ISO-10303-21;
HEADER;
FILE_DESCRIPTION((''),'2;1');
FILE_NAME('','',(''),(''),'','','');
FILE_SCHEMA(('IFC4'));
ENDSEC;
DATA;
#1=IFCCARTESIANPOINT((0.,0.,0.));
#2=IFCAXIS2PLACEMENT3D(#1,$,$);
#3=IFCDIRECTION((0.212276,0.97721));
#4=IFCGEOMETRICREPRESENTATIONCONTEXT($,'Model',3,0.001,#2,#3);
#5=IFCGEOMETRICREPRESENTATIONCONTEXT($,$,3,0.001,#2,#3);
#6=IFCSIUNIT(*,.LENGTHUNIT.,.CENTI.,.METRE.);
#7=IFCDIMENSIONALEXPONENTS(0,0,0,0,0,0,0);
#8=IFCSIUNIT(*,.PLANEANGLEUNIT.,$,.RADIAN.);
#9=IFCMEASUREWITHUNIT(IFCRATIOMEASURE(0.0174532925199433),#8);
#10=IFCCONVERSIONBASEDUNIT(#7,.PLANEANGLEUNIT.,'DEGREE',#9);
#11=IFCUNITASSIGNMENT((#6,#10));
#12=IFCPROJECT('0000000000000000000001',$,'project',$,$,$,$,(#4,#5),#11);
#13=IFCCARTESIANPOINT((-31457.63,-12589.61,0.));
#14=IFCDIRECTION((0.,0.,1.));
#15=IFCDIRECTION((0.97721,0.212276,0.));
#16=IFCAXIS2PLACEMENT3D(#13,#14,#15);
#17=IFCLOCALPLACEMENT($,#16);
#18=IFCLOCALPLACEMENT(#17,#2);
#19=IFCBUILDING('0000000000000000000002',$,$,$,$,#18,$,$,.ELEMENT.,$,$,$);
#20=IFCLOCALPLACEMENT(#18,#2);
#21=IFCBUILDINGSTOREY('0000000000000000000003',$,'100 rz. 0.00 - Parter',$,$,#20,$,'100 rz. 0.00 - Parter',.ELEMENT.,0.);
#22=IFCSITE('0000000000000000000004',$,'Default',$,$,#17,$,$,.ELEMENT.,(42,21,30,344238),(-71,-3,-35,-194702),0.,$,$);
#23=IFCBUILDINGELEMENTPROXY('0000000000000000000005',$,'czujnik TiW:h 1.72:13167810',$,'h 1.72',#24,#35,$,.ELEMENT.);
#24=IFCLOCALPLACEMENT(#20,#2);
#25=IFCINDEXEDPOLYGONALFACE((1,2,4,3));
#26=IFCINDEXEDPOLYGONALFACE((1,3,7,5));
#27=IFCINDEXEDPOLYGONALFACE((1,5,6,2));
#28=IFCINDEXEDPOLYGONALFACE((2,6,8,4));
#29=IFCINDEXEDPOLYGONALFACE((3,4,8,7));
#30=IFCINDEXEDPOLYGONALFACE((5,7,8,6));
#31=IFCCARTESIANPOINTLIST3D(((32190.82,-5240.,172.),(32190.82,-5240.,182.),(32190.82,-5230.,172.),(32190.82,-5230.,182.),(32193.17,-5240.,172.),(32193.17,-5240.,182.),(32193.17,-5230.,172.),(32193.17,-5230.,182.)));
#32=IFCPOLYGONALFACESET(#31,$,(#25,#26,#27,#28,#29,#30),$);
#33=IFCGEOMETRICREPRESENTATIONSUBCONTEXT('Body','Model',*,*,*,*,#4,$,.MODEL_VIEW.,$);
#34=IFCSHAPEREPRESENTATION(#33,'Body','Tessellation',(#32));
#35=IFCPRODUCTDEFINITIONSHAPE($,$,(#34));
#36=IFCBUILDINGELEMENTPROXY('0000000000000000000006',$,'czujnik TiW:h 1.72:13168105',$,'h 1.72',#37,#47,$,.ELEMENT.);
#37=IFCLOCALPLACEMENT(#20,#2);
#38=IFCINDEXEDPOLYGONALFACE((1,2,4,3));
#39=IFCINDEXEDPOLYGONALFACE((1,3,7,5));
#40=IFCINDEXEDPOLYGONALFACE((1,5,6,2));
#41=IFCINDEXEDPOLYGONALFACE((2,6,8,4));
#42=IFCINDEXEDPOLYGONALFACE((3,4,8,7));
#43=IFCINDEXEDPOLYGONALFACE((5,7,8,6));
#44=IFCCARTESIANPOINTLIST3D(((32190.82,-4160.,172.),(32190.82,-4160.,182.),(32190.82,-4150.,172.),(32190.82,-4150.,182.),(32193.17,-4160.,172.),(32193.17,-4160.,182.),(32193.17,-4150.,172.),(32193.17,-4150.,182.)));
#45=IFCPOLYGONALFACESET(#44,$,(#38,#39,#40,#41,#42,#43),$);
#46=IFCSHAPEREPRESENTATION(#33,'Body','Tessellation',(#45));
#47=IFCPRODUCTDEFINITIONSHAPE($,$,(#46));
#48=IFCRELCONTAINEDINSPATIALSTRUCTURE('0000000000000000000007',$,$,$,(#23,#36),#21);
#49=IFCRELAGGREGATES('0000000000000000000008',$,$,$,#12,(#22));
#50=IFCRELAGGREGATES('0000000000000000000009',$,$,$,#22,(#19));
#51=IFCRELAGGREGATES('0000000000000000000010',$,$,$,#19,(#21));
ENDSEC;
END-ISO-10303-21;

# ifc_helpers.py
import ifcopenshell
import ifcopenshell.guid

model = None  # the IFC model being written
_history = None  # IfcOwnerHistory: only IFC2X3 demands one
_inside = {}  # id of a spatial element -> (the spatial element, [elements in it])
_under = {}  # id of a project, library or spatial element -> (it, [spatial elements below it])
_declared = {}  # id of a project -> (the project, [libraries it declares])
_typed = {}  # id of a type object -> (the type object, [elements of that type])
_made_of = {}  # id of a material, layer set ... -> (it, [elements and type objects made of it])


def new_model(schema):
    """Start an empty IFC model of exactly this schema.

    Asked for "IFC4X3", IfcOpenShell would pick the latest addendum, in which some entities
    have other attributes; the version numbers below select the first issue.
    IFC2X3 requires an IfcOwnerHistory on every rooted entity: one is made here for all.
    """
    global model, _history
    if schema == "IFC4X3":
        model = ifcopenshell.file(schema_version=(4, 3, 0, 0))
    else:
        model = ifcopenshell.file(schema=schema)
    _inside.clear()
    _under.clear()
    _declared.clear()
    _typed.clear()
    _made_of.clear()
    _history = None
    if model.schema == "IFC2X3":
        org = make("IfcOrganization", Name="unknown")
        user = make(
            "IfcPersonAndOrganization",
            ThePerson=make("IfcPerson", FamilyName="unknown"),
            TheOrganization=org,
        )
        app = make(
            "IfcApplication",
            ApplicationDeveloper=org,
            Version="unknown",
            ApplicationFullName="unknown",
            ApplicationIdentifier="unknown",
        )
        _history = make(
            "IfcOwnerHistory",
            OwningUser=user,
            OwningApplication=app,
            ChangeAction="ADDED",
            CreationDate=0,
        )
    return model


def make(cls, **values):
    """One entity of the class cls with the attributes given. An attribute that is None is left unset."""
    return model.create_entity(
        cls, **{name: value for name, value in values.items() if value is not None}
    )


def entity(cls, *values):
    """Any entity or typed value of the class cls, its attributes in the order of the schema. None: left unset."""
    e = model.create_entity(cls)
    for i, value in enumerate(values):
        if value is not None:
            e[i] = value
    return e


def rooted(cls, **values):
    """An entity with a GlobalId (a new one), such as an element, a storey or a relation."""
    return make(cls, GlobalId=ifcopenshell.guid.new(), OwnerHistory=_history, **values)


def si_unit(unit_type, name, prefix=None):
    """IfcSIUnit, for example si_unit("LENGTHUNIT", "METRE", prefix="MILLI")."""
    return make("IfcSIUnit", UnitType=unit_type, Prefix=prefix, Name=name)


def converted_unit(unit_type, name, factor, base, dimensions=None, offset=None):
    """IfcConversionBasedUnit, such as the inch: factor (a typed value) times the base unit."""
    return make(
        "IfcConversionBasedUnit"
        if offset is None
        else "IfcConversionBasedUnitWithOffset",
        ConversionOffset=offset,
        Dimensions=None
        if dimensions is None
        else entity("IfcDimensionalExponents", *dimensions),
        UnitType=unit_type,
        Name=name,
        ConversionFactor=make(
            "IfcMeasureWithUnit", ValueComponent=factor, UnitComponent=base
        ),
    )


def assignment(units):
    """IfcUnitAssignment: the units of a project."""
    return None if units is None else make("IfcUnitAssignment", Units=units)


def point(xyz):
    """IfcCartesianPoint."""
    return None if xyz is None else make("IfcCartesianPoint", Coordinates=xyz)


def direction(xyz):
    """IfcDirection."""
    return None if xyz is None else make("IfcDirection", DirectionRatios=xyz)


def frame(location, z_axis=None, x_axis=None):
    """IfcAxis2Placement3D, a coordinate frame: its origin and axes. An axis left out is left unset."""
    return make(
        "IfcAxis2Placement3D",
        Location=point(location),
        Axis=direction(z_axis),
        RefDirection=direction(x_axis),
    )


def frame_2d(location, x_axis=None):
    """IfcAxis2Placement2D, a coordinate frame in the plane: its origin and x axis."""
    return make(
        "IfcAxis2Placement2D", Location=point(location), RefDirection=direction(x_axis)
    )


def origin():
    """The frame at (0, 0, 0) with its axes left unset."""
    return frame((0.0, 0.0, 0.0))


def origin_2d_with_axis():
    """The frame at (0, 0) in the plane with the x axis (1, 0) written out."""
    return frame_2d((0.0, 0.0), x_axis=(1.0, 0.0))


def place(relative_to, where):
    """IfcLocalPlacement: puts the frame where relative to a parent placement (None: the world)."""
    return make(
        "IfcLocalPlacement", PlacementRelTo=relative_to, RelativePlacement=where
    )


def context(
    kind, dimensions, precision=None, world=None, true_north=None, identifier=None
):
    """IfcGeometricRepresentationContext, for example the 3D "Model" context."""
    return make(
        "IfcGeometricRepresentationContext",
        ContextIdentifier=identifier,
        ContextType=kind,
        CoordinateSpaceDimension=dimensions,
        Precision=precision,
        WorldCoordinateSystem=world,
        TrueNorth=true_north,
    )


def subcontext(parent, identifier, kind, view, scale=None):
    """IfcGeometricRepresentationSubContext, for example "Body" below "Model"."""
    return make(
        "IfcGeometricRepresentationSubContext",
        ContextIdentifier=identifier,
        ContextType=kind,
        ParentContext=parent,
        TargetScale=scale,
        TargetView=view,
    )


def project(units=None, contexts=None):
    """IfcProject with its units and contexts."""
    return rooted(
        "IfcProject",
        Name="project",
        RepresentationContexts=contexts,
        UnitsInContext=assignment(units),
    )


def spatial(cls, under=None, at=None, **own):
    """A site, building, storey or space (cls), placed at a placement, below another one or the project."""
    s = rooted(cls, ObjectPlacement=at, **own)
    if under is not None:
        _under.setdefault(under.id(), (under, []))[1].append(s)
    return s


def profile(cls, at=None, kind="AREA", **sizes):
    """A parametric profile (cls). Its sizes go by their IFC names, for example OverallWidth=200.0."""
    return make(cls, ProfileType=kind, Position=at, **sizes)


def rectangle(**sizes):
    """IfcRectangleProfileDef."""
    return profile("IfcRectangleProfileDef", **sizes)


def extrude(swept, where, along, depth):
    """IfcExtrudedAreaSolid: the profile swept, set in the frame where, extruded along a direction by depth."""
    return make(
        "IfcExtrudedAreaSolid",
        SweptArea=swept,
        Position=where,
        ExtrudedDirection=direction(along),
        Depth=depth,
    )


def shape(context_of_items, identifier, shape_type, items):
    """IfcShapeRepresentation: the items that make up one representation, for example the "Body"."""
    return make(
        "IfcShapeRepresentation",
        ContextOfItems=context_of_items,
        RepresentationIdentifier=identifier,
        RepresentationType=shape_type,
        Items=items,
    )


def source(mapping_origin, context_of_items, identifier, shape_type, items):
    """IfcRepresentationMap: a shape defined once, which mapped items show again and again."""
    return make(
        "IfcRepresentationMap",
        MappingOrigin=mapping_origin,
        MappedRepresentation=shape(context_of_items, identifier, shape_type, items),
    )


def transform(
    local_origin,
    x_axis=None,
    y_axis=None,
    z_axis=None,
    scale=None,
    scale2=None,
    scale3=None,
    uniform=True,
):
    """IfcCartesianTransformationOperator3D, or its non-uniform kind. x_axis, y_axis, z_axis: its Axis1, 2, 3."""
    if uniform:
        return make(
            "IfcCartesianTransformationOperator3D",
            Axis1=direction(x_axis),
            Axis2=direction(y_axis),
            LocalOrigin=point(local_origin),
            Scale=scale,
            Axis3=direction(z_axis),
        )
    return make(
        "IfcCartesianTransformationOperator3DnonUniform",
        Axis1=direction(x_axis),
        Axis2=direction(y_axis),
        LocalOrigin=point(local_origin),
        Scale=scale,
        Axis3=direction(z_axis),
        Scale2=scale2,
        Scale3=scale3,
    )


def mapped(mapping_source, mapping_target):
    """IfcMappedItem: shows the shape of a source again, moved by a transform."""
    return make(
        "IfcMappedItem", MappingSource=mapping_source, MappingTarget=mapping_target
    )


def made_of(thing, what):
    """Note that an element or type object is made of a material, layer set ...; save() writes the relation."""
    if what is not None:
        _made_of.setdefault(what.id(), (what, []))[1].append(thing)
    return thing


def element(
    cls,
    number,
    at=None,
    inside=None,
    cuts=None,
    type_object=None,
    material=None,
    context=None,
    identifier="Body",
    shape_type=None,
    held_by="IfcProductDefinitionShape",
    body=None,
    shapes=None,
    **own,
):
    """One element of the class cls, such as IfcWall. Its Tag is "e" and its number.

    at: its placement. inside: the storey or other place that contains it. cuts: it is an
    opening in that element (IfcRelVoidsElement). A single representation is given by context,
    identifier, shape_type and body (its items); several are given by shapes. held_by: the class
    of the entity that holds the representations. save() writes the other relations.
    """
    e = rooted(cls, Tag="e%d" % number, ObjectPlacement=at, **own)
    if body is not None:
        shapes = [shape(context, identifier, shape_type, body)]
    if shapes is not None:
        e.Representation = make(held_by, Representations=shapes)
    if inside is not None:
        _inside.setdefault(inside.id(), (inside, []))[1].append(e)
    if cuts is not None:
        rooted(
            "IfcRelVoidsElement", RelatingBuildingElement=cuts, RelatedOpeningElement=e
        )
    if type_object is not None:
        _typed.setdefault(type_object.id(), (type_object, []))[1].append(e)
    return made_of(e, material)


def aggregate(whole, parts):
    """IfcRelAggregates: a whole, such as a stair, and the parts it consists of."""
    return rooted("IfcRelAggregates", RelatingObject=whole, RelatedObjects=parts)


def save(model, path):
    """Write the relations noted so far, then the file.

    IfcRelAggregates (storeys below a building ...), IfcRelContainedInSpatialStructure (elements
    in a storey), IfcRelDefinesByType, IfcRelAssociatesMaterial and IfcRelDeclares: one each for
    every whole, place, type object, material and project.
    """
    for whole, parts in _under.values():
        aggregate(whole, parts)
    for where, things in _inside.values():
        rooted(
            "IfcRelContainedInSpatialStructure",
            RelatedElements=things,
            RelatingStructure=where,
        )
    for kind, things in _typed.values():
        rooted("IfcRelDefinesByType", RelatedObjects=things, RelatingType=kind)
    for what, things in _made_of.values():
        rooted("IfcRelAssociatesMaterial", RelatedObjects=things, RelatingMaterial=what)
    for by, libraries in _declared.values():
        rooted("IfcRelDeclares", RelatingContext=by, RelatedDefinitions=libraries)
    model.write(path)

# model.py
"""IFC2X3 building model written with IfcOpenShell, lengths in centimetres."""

from ifc_helpers import new_model, entity, si_unit, converted_unit, direction, frame, origin, origin_2d_with_axis, place, context, subcontext, project, spatial, rectangle, extrude, source, transform, mapped, element, save


model = new_model("IFC2X3")

# Units and contexts
model_context = context("Model", 3, precision=0.001, world=origin(), true_north=direction((0.212276, 0.97721)))
context_of_model = context(None, 3, precision=0.001, world=origin(), true_north=direction((0.212276, 0.97721)))
body_context = subcontext(model_context, "Body", "Model", "MODEL_VIEW")
ifc_project = project(units=[si_unit("LENGTHUNIT", "METRE", prefix="CENTI"), converted_unit("PLANEANGLEUNIT", "DEGREE", entity("IfcRatioMeasure", 0.0174532925199433), si_unit("PLANEANGLEUNIT", "RADIAN"), dimensions=[0, 0, 0, 0, 0, 0, 0])], contexts=[model_context, context_of_model])

# Site, building, storey
site_placement = place(None, frame((-31457.63, -12589.61, 0.0), z_axis=(0.0, 0.0, 1.0), x_axis=(0.97721, 0.212276, 0.0)))
site = spatial("IfcSite", under=ifc_project, at=site_placement, Name="Default", CompositionType="ELEMENT", RefLatitude=(42, 21, 30, 344238), RefLongitude=(-71, -3, -35, -194702), RefElevation=0.0)
building_placement = place(site_placement, origin())
building = spatial("IfcBuilding", under=site, at=building_placement, CompositionType="ELEMENT")
storey_placement = place(building_placement, origin())
storey = spatial("IfcBuildingStorey", under=building, at=storey_placement, Name="100 rz. 0.00 - Parter", LongName="100 rz. 0.00 - Parter", CompositionType="ELEMENT", Elevation=0.0)

# Building element proxies
shared_shape_1 = source(origin(), body_context, "Body", "SweptSolid", [
    extrude(rectangle(XDim=2.35, YDim=10.0, at=origin_2d_with_axis()), frame((5.0, 1.18, 0.0), z_axis=(0.0, 0.0, 1.0), x_axis=(0.0, 1.0, 0.0)), (0.0, 0.0, 1.0), 10.0),
])
for number, where, z_axis, x_axis, name in (
    (1, (32190.82, -5230.0, 172.0), (0.0, 0.0, 1.0), (0.0, -1.0, 0.0), "czujnik TiW:h 1.72:13167810"),
    (2, (32190.82, -4150.0, 172.0), (0.0, 0.0, 1.0), (0.0, -1.0, 0.0), "czujnik TiW:h 1.72:13168105"),
):
    element("IfcBuildingElementProxy", number, at=place(storey_placement, frame(where, z_axis=z_axis, x_axis=x_axis)), inside=storey, Name=name, ObjectType="h 1.72", CompositionType="ELEMENT", context=body_context, shape_type="MappedRepresentation", body=[
        mapped(shared_shape_1, transform((0.0, 0.0, 0.0), scale=1.0)),
    ])

save(model, "model.ifc")
